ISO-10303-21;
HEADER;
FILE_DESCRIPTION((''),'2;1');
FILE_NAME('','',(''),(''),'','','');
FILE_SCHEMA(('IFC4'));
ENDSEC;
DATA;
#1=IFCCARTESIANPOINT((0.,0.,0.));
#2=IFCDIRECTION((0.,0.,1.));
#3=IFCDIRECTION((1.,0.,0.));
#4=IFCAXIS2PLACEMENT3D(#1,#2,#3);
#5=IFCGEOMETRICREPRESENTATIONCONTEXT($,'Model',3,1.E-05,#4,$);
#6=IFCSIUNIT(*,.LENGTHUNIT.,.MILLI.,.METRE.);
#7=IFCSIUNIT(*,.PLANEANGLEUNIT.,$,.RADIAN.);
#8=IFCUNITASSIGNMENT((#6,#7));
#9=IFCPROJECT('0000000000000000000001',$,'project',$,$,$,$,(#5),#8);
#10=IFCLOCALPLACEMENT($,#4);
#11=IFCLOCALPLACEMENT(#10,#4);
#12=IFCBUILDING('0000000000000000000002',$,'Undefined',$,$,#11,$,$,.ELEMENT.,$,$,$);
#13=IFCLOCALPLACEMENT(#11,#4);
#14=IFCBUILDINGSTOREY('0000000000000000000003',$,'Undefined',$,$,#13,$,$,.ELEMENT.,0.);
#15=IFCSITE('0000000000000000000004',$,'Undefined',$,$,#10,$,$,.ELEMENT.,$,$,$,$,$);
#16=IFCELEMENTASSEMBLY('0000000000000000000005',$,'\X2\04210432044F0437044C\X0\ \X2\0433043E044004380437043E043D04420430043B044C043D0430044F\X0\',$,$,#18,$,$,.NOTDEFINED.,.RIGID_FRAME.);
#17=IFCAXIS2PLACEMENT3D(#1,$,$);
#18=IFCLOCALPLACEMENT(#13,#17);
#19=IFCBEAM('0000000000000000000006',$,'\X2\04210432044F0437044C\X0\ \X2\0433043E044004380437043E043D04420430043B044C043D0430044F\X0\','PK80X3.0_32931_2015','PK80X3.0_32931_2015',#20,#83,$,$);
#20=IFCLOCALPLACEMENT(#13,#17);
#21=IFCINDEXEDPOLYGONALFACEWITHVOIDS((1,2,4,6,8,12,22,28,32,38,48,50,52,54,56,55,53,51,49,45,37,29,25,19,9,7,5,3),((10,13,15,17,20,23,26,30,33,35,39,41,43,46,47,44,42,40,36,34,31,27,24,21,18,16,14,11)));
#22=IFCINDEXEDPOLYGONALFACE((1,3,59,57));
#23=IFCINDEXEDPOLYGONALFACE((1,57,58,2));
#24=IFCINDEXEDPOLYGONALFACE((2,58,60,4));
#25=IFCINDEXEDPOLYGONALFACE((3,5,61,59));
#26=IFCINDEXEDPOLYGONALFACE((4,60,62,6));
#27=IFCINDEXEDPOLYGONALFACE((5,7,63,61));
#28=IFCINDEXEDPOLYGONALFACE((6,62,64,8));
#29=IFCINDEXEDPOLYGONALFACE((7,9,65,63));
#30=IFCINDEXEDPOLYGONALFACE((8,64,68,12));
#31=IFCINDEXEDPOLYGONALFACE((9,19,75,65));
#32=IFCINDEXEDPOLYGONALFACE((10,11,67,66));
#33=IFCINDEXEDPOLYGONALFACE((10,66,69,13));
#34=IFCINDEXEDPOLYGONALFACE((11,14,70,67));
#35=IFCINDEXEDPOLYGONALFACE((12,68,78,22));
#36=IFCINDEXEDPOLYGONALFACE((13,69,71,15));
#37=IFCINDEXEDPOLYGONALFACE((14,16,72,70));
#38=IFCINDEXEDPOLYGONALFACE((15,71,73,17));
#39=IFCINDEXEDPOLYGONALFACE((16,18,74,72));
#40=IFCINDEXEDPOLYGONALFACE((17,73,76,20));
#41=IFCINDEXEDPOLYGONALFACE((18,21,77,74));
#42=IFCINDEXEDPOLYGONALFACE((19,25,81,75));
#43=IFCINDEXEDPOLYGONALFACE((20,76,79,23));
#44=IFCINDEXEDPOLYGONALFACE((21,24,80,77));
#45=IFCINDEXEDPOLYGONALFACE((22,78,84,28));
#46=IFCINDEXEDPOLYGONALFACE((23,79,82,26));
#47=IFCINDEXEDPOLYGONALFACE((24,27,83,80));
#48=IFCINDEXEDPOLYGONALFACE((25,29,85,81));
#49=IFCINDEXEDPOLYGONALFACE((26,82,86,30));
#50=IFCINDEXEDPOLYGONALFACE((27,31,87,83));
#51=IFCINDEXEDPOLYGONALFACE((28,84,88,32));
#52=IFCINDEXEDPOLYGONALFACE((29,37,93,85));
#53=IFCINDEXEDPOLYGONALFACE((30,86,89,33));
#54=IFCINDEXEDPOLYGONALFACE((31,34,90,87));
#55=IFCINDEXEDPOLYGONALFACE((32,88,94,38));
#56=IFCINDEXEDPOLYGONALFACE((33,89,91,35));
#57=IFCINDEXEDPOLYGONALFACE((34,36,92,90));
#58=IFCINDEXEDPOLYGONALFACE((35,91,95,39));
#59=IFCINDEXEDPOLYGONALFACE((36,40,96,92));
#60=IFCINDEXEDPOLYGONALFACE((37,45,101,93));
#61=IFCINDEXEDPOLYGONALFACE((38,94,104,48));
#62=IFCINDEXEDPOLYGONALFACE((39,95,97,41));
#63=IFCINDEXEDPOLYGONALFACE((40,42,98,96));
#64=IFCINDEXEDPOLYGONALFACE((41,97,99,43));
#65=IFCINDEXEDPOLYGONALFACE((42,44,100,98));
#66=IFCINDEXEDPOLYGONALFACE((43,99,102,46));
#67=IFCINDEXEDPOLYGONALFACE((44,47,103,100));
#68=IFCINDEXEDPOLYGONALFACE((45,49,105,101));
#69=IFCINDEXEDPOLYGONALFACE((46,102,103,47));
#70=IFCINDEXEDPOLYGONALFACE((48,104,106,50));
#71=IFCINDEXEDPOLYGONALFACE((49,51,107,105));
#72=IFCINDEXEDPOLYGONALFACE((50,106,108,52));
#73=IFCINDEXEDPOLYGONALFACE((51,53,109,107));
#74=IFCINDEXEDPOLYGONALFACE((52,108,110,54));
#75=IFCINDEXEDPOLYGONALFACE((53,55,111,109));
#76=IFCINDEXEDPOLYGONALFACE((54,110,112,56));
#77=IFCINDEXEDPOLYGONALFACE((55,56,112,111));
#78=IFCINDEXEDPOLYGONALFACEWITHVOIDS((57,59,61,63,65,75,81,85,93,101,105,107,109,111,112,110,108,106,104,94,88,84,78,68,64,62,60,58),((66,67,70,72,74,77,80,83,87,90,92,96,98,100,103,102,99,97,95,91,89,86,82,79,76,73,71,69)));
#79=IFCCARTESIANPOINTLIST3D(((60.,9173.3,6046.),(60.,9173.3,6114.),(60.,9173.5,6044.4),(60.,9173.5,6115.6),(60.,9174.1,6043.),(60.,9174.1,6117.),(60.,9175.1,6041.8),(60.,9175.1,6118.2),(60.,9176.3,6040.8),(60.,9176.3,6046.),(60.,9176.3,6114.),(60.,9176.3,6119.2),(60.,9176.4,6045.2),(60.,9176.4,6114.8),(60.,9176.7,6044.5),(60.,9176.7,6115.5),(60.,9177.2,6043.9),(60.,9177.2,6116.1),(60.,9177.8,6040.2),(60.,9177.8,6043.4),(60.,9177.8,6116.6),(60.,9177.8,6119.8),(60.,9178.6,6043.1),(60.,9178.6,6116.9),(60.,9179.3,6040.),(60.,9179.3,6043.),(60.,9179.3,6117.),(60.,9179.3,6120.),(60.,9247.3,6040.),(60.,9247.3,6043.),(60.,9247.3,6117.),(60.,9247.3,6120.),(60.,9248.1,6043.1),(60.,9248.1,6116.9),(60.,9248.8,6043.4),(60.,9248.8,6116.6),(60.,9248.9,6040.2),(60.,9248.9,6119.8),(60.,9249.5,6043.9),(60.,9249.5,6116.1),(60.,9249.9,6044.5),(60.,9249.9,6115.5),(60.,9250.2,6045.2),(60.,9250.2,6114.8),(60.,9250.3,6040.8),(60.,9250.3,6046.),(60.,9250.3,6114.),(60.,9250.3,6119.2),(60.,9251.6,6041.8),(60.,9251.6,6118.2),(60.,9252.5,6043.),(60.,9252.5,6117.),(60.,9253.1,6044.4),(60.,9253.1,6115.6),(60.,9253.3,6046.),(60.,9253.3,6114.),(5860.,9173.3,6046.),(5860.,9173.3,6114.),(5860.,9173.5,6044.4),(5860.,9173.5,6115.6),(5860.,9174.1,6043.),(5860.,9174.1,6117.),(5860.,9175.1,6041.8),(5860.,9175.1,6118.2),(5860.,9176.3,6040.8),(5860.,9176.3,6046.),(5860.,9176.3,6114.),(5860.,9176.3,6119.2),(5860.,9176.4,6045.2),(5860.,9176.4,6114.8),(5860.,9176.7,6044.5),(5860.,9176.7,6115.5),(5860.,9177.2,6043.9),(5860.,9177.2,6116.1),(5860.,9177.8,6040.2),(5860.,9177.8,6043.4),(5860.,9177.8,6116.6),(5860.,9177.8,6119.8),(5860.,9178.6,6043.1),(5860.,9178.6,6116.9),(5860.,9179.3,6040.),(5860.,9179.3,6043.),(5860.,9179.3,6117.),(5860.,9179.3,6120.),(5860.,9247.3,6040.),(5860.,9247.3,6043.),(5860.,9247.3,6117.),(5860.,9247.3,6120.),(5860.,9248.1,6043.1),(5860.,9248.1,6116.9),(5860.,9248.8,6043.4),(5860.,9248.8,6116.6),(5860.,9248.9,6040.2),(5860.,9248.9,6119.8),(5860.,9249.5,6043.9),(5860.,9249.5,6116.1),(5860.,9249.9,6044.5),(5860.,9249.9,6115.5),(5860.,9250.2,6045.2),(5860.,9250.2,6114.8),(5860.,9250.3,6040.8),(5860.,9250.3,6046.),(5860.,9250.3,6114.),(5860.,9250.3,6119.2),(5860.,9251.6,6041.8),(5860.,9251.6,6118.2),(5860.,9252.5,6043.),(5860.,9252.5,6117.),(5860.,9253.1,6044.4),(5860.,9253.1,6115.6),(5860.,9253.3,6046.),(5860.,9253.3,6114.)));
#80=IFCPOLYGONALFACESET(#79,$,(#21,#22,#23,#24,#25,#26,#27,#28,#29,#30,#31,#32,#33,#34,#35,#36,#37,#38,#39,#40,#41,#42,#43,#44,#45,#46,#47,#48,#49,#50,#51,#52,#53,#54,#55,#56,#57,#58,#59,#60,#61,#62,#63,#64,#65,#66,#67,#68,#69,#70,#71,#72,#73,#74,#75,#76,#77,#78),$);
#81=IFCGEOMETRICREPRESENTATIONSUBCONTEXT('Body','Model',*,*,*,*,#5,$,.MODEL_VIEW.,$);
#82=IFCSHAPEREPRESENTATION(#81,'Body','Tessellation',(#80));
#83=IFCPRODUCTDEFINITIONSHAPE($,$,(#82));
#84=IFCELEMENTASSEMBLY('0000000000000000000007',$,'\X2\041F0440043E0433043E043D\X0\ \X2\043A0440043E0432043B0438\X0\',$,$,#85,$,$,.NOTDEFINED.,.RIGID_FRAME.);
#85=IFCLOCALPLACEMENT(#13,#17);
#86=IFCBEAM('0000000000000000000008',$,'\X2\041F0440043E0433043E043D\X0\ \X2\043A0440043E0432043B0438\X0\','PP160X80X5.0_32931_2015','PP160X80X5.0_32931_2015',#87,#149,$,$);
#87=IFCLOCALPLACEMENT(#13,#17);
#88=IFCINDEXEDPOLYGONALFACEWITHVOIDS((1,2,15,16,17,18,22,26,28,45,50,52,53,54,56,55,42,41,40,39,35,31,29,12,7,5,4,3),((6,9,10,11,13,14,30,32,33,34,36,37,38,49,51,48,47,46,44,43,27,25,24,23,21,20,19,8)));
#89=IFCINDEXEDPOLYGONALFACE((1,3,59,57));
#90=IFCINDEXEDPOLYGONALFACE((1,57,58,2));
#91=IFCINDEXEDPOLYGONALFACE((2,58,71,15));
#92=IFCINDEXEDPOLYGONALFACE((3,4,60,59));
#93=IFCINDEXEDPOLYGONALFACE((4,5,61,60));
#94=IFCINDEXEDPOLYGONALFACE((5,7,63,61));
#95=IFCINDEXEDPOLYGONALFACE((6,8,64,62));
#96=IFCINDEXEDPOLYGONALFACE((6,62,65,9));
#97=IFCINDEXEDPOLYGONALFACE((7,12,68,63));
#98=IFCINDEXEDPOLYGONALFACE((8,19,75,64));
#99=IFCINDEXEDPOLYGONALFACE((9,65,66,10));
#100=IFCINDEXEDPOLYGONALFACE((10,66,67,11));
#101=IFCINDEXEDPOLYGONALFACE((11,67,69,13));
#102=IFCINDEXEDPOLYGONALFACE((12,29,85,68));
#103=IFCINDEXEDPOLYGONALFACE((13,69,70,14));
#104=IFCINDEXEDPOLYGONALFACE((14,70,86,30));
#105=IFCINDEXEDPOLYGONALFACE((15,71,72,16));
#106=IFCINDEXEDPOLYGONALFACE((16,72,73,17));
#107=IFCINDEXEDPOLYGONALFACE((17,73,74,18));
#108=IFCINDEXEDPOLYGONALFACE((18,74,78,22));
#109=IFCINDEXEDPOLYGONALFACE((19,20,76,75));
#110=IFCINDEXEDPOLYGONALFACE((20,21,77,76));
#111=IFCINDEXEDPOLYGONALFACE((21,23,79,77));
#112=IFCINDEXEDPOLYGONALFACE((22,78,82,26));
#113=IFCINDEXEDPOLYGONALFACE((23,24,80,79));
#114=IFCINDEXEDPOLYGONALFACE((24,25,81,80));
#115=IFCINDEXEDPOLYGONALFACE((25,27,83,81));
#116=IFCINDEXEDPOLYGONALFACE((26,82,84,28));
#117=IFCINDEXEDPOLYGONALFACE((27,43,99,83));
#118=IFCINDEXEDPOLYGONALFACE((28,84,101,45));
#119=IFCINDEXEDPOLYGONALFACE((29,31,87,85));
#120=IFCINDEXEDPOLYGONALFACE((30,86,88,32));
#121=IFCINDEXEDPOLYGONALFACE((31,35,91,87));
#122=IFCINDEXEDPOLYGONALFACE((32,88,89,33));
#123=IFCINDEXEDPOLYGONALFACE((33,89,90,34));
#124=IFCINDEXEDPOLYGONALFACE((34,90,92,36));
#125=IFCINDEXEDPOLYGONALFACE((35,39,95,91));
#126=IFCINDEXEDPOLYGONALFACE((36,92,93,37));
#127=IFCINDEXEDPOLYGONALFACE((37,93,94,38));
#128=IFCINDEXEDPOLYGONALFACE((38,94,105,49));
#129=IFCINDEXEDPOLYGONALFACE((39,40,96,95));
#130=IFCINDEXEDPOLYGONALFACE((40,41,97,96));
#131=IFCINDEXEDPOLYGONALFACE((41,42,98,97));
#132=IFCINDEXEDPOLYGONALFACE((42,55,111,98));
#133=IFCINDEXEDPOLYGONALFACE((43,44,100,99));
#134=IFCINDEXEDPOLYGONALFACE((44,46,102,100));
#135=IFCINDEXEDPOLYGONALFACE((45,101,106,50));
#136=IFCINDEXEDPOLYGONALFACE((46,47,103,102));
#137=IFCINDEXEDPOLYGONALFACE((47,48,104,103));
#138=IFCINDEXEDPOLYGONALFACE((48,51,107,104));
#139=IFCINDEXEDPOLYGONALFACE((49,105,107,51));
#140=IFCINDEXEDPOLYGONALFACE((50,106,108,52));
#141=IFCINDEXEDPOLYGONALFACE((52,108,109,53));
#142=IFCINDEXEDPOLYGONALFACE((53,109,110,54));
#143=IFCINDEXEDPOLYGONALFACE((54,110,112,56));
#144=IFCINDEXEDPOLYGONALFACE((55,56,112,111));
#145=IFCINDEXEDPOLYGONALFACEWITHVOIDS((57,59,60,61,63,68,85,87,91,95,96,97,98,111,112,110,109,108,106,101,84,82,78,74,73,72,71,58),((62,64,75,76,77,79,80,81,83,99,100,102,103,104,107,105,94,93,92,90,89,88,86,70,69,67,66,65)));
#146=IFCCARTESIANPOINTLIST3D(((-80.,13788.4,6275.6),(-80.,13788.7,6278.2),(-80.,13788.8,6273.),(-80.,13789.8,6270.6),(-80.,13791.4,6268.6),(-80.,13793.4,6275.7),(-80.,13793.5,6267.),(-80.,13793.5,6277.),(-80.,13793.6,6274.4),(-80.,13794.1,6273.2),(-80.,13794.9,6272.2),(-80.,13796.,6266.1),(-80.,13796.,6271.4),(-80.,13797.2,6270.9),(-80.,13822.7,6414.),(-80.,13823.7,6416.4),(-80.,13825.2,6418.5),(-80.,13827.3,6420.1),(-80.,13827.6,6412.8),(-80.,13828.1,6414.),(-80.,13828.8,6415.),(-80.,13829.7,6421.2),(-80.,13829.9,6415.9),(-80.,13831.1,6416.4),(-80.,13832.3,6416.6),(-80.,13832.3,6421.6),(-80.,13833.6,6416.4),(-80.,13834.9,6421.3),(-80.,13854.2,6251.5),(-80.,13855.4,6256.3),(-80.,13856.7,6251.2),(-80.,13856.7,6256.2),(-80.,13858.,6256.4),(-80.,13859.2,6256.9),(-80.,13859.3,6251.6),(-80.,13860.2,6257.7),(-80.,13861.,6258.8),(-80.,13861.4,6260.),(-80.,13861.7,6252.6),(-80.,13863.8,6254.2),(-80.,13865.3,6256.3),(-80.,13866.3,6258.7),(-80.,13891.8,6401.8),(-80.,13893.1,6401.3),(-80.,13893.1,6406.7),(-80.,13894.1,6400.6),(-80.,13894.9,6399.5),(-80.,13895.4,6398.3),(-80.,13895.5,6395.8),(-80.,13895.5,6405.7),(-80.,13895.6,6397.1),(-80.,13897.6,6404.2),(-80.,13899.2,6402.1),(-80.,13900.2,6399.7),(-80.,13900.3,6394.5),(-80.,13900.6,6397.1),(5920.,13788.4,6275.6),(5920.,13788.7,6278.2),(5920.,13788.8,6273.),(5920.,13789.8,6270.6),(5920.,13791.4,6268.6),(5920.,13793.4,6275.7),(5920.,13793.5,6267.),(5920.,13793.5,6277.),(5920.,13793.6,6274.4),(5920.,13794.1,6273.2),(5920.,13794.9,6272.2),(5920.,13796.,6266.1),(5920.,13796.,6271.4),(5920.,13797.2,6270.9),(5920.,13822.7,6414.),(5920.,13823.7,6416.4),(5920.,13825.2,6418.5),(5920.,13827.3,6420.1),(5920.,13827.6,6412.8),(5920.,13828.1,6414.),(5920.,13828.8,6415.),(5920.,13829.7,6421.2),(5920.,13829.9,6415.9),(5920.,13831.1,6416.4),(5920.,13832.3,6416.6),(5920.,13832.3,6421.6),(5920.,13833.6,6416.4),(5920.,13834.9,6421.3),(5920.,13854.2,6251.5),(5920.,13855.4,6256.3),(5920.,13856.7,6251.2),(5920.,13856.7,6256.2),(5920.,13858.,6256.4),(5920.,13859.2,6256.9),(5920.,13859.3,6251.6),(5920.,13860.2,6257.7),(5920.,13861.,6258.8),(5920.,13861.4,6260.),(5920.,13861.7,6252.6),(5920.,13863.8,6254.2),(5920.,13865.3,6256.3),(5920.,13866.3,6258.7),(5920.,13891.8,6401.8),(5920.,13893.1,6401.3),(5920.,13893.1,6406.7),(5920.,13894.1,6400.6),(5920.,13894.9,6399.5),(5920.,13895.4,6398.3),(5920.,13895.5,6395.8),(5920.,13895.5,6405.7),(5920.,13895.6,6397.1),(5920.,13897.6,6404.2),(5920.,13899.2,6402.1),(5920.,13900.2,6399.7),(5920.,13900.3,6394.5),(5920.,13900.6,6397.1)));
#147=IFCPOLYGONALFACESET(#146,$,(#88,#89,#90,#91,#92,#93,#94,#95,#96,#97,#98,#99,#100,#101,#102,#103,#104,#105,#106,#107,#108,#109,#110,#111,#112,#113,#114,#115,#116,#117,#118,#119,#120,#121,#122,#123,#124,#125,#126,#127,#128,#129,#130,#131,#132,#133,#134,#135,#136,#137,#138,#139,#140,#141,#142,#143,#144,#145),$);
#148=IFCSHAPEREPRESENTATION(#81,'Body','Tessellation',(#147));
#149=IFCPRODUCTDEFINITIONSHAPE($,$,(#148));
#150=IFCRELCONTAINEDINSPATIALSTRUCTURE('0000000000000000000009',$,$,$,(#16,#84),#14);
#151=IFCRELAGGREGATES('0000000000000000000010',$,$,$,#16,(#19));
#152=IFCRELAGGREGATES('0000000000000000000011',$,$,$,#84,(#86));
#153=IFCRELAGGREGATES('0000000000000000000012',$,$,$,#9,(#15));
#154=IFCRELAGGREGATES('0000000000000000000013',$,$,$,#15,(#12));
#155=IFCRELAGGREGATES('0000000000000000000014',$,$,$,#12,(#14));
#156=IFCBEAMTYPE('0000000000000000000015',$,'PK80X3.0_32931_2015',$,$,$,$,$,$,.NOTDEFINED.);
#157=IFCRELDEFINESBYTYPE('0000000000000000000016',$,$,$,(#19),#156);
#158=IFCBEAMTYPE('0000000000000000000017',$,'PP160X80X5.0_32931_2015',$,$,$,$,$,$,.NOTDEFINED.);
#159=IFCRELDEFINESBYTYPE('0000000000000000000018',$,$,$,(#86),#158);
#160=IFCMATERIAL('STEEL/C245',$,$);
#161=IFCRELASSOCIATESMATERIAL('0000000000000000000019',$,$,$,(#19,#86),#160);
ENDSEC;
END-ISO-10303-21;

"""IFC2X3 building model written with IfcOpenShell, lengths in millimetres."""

from ifc_helpers import new_model, si_unit, frame, origin_with_axes, origin_2d_with_axis, place, context, subcontext, project, spatial, hollow_rectangle, extrude, material, type_object, element, aggregate, save


model = new_model("IFC2X3")

# Units and contexts
model_context = context("Model", 3, precision=1e-05, world=origin_with_axes())
body_context = subcontext(model_context, "Body", "Model", "MODEL_VIEW")
ifc_project = project(units=[si_unit("LENGTHUNIT", "METRE", prefix="MILLI"), si_unit("PLANEANGLEUNIT", "RADIAN")], contexts=[model_context])

# Site, building, storey
site_placement = place(None, origin_with_axes())
site = spatial("IfcSite", under=ifc_project, at=site_placement, Name="Undefined", CompositionType="ELEMENT")
building_placement = place(site_placement, origin_with_axes())
building = spatial("IfcBuilding", under=site, at=building_placement, Name="Undefined", CompositionType="ELEMENT")
storey_placement = place(building_placement, origin_with_axes())
storey = spatial("IfcBuildingStorey", under=building, at=storey_placement, Name="Undefined", CompositionType="ELEMENT", Elevation=0.0)

# Shared definitions
ifc_material = material(Name="STEEL/C245")

# Element assemblies, beams
beam_type_1 = type_object("IfcBeamType", Name="PK80X3.0_32931_2015", PredefinedType="NOTDEFINED")
assembly_1_placement = place(storey_placement, origin_with_axes())
assembly_1 = element("IfcElementAssembly", 1, at=assembly_1_placement, inside=storey, Name="Связь горизонтальная", AssemblyPlace="NOTDEFINED", PredefinedType="RIGID_FRAME")
beam_1_placement = place(assembly_1_placement, frame((60.0, 9213.3, 6080.0), z_axis=(0.0, 0.0, 1.0), x_axis=(1.0, 0.0, 0.0)))
beam_1 = element("IfcBeam", 2, at=beam_1_placement, type_object=beam_type_1, material=ifc_material, Name="Связь горизонтальная", Description="PK80X3.0_32931_2015", ObjectType="PK80X3.0_32931_2015", context=body_context, shape_type="SweptSolid", body=[
    extrude(hollow_rectangle(XDim=80.0, YDim=80.0, WallThickness=3.0, InnerFilletRadius=3.0, OuterFilletRadius=6.0, at=origin_2d_with_axis()), frame((5800.0, 0.0, 0.0), z_axis=(-1.0, 0.0, 0.0), x_axis=(0.0, -1.0, 0.0)), (0.0, 0.0, 1.0), 5800.0),
])
aggregate(assembly_1, [beam_1])
assembly_2_placement = place(storey_placement, origin_with_axes())
assembly_2 = element("IfcElementAssembly", 3, at=assembly_2_placement, inside=storey, Name="Прогон кровли", AssemblyPlace="NOTDEFINED", PredefinedType="RIGID_FRAME")
beam_type_2 = type_object("IfcBeamType", Name="PP160X80X5.0_32931_2015", PredefinedType="NOTDEFINED")
beam_2_placement = place(assembly_2_placement, frame((-80.0, 13844.5, 6336.4), z_axis=(0.0, 0.243188, 0.969979), x_axis=(1.0, 0.0, 0.0)))
beam_2 = element("IfcBeam", 4, at=beam_2_placement, type_object=beam_type_2, material=ifc_material, Name="Прогон кровли", Description="PP160X80X5.0_32931_2015", ObjectType="PP160X80X5.0_32931_2015", context=body_context, shape_type="SweptSolid", body=[
    extrude(hollow_rectangle(XDim=80.0, YDim=160.0, WallThickness=5.0, InnerFilletRadius=5.0, OuterFilletRadius=10.0, at=origin_2d_with_axis()), frame((6000.0, 0.0, 0.0), z_axis=(-1.0, 0.0, 0.0), x_axis=(0.0, -1.0, 0.0)), (0.0, 0.0, 1.0), 6000.0),
])
aggregate(assembly_2, [beam_2])

save(model, "model.ifc")
